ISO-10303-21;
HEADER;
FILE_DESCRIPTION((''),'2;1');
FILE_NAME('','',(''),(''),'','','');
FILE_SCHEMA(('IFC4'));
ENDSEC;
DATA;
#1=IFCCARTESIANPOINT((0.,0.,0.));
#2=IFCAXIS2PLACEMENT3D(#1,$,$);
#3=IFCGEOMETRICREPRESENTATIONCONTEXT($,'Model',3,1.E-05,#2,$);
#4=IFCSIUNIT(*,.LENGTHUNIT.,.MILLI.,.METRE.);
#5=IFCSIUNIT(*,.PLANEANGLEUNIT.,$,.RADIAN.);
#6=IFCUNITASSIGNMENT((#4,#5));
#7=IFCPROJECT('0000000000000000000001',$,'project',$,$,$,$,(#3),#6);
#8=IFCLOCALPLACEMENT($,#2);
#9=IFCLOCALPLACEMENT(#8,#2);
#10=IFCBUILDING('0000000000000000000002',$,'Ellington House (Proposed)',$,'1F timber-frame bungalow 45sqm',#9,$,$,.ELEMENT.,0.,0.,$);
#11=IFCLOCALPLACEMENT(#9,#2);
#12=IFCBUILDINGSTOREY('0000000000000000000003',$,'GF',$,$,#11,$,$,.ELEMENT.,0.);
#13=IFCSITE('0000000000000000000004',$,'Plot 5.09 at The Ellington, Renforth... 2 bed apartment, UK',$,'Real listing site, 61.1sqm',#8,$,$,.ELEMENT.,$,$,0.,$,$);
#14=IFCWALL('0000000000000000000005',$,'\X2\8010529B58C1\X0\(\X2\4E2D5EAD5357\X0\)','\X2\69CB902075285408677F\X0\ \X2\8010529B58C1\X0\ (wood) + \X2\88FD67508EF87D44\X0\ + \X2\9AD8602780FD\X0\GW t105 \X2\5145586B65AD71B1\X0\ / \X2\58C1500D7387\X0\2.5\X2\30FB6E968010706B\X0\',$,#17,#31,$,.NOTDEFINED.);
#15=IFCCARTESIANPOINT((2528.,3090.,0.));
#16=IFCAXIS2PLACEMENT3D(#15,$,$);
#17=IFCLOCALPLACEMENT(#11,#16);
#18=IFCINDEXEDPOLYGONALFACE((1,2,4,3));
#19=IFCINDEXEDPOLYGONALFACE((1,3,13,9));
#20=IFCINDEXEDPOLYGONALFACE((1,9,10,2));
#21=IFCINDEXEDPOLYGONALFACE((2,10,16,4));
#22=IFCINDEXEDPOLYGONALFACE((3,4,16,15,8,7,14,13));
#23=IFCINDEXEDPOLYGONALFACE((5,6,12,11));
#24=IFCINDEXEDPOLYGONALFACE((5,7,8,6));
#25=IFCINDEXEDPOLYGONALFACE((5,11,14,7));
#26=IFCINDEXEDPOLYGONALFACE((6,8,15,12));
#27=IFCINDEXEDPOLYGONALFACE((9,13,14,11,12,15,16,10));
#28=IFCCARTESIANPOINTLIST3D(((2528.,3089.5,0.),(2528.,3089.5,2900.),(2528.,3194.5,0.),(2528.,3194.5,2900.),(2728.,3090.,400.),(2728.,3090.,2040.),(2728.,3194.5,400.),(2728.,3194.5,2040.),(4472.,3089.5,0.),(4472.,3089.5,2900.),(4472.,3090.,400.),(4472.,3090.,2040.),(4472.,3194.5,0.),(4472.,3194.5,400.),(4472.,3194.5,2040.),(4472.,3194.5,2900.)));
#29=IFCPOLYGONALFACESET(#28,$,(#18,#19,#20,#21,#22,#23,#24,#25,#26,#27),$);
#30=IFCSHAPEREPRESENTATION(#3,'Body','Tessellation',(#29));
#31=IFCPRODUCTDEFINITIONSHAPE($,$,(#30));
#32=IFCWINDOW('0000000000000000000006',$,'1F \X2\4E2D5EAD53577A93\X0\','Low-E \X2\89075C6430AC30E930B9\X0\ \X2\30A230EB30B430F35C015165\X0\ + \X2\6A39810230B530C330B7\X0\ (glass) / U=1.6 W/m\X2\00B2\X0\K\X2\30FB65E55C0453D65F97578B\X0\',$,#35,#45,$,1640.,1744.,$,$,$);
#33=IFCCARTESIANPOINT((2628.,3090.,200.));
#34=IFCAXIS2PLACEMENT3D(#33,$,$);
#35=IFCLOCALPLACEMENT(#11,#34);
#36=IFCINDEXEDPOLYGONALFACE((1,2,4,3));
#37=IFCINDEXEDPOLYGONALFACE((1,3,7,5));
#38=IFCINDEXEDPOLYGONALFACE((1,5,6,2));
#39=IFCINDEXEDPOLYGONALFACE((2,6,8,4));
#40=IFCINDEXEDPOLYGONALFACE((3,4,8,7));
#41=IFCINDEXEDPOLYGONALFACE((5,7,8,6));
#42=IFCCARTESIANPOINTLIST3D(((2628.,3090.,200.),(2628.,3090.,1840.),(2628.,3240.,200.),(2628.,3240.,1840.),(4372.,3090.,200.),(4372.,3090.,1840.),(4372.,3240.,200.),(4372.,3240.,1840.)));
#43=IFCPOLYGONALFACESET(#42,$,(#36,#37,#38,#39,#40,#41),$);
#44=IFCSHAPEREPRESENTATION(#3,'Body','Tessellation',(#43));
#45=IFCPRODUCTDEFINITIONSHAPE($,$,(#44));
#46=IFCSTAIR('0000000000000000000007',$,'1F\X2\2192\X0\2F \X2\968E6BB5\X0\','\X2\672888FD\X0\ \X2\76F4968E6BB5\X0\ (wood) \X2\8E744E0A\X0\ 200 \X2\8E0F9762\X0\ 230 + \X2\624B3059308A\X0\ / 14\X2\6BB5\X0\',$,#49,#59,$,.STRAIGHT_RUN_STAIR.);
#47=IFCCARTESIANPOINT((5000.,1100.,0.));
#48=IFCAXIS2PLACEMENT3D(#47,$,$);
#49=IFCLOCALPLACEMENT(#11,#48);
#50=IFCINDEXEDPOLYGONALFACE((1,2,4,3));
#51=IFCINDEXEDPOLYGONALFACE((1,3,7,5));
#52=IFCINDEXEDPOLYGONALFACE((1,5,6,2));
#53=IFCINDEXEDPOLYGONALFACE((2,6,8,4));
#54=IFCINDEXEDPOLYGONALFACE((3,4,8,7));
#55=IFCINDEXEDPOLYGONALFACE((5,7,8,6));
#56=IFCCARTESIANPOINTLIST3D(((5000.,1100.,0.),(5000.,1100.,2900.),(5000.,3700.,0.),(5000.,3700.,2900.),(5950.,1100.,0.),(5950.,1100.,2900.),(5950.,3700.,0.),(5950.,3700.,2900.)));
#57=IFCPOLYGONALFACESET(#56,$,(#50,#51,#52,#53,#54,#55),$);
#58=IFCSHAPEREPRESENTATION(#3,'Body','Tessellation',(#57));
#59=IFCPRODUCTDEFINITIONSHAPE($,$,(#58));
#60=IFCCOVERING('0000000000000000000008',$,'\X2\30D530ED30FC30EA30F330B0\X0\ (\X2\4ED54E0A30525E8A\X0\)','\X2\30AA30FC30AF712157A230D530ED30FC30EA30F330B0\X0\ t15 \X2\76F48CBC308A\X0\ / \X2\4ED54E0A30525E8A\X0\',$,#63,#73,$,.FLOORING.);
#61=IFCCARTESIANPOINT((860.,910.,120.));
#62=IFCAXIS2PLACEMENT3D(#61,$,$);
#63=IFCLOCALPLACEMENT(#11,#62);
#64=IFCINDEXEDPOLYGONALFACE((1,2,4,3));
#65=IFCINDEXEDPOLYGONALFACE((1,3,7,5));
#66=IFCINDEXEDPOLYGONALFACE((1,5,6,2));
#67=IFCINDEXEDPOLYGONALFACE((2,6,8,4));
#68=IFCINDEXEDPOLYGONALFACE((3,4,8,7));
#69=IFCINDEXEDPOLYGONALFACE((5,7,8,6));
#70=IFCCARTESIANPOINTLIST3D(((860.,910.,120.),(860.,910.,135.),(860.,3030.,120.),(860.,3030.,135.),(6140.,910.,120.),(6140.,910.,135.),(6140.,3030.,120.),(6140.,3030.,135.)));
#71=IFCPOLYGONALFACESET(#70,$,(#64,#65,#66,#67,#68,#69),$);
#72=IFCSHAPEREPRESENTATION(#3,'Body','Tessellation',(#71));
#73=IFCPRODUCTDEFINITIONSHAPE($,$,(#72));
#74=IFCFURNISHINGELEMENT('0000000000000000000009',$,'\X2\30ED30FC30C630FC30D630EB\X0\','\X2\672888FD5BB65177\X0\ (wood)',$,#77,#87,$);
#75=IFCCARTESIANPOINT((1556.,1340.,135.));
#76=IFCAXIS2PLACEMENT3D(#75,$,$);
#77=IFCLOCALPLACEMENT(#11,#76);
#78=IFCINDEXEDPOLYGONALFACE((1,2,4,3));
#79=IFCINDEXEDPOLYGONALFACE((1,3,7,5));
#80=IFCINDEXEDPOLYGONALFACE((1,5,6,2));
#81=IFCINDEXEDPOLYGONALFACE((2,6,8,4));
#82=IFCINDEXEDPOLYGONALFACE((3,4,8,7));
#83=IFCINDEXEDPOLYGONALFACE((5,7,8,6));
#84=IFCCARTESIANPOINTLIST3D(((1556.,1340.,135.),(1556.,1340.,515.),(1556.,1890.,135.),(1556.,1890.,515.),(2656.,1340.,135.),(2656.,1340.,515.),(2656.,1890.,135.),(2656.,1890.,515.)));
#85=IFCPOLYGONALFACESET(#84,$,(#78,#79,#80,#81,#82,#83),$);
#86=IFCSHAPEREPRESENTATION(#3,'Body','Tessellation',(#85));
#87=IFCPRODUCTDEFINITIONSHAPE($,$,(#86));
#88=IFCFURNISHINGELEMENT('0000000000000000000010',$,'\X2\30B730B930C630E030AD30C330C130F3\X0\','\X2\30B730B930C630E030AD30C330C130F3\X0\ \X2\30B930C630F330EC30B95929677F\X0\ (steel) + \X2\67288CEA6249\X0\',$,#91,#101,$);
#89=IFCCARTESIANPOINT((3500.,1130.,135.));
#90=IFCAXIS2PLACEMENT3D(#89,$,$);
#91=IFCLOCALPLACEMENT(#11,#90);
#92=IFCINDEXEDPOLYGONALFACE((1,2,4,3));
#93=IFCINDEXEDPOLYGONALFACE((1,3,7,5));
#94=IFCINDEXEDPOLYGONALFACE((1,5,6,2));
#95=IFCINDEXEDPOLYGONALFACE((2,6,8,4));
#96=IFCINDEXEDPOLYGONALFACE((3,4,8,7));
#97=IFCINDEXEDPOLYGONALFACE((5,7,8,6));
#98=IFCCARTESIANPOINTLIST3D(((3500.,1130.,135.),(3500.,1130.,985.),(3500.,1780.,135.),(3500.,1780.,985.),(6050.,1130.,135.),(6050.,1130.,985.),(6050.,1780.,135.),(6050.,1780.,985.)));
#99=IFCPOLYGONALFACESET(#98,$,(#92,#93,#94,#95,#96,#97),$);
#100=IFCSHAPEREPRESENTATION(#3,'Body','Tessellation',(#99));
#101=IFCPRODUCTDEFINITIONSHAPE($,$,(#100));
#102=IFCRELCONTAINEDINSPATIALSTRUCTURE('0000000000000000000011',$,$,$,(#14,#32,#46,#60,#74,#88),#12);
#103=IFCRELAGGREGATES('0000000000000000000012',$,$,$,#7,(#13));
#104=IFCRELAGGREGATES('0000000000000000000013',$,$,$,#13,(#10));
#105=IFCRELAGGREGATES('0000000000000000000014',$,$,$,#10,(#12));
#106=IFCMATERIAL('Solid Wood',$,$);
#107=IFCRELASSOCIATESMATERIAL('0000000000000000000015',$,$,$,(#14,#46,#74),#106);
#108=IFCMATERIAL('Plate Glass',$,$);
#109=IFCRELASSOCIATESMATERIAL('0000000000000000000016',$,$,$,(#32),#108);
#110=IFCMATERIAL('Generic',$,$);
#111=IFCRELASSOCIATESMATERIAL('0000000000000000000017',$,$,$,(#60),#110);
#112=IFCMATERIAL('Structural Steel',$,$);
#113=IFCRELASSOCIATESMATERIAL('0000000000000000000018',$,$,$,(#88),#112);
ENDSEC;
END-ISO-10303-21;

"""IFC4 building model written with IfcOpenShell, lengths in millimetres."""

from ifc_helpers import new_model, si_unit, frame, frame_2d, origin, place, context, project, spatial, rectangle, extrude, material, element, fill, save


model = new_model("IFC4")

# Units and contexts
model_context = context("Model", 3, precision=1e-05, world=origin())
ifc_project = project(units=[si_unit("LENGTHUNIT", "METRE", prefix="MILLI"), si_unit("PLANEANGLEUNIT", "RADIAN")], contexts=[model_context])

# Site, building, storey
site_placement = place(None, origin())
site = spatial("IfcSite", under=ifc_project, at=site_placement, Name="Plot 5.09 at The Ellington, Renforth... 2 bed apartment, UK", ObjectType="Real listing site, 61.1sqm", CompositionType="ELEMENT", RefElevation=0.0)
building_placement = place(site_placement, origin())
building = spatial("IfcBuilding", under=site, at=building_placement, Name="Ellington House (Proposed)", ObjectType="1F timber-frame bungalow 45sqm", CompositionType="ELEMENT", ElevationOfRefHeight=0.0, ElevationOfTerrain=0.0)
storey_placement = place(building_placement, origin())
storey = spatial("IfcBuildingStorey", under=building, at=storey_placement, Name="GF", CompositionType="ELEMENT", Elevation=0.0)

# Shared definitions
ifc_material_1 = material(Name="Solid Wood")

# Shared definitions
ifc_material_2 = material(Name="Plate Glass")
ifc_material_3 = material(Name="Generic")

# Wall, opening, window
wall_1_placement = place(storey_placement, frame((2528.0, 3090.0, 0.0)))
wall_1 = element("IfcWall", 1, at=wall_1_placement, inside=storey, material=ifc_material_1, Name="耐力壁(中庭南)", Description="構造用合板 耐力壁 (wood) + 製材軸組 + 高性能GW t105 充填断熱 / 壁倍率2.5・準耐火", PredefinedType="NOTDEFINED", context=model_context, shape_type="SweptSolid", body=[
    extrude(rectangle(XDim=1944.0, YDim=105.0, at=frame_2d((972.0, 52.0))), frame((2528.0, 3090.0, 0.0)), (0.0, 0.0, 1.0), 2900.0),
])
opening_1_placement = place(storey_placement, frame((2628.0, 3090.0, 200.0)))
opening_1 = element("IfcOpeningElement", 2, at=opening_1_placement, cuts=wall_1, PredefinedType="NOTDEFINED", context=model_context, shape_type="SweptSolid", body=[
    extrude(rectangle(XDim=1744.0, YDim=150.0, at=frame_2d((872.0, 75.0))), frame((2628.0, 3090.0, 200.0)), (0.0, 0.0, 1.0), 1640.0),
])
window_1_placement = place(storey_placement, frame((2628.0, 3090.0, 200.0)))
window_1 = element("IfcWindow", 3, at=window_1_placement, inside=storey, material=ifc_material_2, Name="1F 中庭南窓", Description="Low-E 複層ガラス アルゴン封入 + 樹脂サッシ (glass) / U=1.6 W/m²K・日射取得型", OverallHeight=1640.0, OverallWidth=1744.0, context=model_context, shape_type="SweptSolid", body=[
    extrude(rectangle(XDim=1744.0, YDim=150.0, at=frame_2d((872.0, 75.0))), frame((2628.0, 3090.0, 200.0)), (0.0, 0.0, 1.0), 1640.0),
])
fill(opening_1, window_1)

# Stair
stair_placement = place(storey_placement, frame((5000.0, 1100.0, 0.0)))
element("IfcStair", 4, at=stair_placement, inside=storey, material=ifc_material_1, Name="1F→2F 階段", Description="木製 直階段 (wood) 蹴上 200 踏面 230 + 手すり / 14段", PredefinedType="STRAIGHT_RUN_STAIR", context=model_context, shape_type="SweptSolid", body=[
    extrude(rectangle(XDim=950.0, YDim=2600.0, at=frame_2d((475.0, 1300.0))), frame((5000.0, 1100.0, 0.0)), (0.0, 0.0, 1.0), 2900.0),
])

# Covering
covering_placement = place(storey_placement, frame((860.0, 910.0, 120.0)))
element("IfcCovering", 5, at=covering_placement, inside=storey, material=ifc_material_3, Name="フローリング (仕上げ床)", Description="オーク無垢フローリング t15 直貼り / 仕上げ床", PredefinedType="FLOORING", context=model_context, shape_type="SweptSolid", body=[
    extrude(rectangle(XDim=5280.0, YDim=2120.0, at=frame_2d((2640.0, 1060.0))), frame((860.0, 910.0, 120.0)), (0.0, 0.0, 1.0), 15.0),
])

# Furnishing elements
furnishing_1_placement = place(storey_placement, frame((1556.0, 1340.0, 135.0)))
element("IfcFurnishingElement", 6, at=furnishing_1_placement, inside=storey, material=ifc_material_1, Name="ローテーブル", Description="木製家具 (wood)", context=model_context, shape_type="SweptSolid", body=[
    extrude(rectangle(XDim=1100.0, YDim=550.0, at=frame_2d((550.0, 275.0))), frame((1556.0, 1340.0, 135.0)), (0.0, 0.0, 1.0), 380.0),
])
ifc_material_4 = material(Name="Structural Steel")
furnishing_2_placement = place(storey_placement, frame((3500.0, 1130.0, 135.0)))
element("IfcFurnishingElement", 7, at=furnishing_2_placement, inside=storey, material=ifc_material_4, Name="システムキッチン", Description="システムキッチン ステンレス天板 (steel) + 木質扉", context=model_context, shape_type="SweptSolid", body=[
    extrude(rectangle(XDim=2550.0, YDim=650.0, at=frame_2d((1275.0, 325.0))), frame((3500.0, 1130.0, 135.0)), (0.0, 0.0, 1.0), 850.0),
])

save(model, "model.ifc")
